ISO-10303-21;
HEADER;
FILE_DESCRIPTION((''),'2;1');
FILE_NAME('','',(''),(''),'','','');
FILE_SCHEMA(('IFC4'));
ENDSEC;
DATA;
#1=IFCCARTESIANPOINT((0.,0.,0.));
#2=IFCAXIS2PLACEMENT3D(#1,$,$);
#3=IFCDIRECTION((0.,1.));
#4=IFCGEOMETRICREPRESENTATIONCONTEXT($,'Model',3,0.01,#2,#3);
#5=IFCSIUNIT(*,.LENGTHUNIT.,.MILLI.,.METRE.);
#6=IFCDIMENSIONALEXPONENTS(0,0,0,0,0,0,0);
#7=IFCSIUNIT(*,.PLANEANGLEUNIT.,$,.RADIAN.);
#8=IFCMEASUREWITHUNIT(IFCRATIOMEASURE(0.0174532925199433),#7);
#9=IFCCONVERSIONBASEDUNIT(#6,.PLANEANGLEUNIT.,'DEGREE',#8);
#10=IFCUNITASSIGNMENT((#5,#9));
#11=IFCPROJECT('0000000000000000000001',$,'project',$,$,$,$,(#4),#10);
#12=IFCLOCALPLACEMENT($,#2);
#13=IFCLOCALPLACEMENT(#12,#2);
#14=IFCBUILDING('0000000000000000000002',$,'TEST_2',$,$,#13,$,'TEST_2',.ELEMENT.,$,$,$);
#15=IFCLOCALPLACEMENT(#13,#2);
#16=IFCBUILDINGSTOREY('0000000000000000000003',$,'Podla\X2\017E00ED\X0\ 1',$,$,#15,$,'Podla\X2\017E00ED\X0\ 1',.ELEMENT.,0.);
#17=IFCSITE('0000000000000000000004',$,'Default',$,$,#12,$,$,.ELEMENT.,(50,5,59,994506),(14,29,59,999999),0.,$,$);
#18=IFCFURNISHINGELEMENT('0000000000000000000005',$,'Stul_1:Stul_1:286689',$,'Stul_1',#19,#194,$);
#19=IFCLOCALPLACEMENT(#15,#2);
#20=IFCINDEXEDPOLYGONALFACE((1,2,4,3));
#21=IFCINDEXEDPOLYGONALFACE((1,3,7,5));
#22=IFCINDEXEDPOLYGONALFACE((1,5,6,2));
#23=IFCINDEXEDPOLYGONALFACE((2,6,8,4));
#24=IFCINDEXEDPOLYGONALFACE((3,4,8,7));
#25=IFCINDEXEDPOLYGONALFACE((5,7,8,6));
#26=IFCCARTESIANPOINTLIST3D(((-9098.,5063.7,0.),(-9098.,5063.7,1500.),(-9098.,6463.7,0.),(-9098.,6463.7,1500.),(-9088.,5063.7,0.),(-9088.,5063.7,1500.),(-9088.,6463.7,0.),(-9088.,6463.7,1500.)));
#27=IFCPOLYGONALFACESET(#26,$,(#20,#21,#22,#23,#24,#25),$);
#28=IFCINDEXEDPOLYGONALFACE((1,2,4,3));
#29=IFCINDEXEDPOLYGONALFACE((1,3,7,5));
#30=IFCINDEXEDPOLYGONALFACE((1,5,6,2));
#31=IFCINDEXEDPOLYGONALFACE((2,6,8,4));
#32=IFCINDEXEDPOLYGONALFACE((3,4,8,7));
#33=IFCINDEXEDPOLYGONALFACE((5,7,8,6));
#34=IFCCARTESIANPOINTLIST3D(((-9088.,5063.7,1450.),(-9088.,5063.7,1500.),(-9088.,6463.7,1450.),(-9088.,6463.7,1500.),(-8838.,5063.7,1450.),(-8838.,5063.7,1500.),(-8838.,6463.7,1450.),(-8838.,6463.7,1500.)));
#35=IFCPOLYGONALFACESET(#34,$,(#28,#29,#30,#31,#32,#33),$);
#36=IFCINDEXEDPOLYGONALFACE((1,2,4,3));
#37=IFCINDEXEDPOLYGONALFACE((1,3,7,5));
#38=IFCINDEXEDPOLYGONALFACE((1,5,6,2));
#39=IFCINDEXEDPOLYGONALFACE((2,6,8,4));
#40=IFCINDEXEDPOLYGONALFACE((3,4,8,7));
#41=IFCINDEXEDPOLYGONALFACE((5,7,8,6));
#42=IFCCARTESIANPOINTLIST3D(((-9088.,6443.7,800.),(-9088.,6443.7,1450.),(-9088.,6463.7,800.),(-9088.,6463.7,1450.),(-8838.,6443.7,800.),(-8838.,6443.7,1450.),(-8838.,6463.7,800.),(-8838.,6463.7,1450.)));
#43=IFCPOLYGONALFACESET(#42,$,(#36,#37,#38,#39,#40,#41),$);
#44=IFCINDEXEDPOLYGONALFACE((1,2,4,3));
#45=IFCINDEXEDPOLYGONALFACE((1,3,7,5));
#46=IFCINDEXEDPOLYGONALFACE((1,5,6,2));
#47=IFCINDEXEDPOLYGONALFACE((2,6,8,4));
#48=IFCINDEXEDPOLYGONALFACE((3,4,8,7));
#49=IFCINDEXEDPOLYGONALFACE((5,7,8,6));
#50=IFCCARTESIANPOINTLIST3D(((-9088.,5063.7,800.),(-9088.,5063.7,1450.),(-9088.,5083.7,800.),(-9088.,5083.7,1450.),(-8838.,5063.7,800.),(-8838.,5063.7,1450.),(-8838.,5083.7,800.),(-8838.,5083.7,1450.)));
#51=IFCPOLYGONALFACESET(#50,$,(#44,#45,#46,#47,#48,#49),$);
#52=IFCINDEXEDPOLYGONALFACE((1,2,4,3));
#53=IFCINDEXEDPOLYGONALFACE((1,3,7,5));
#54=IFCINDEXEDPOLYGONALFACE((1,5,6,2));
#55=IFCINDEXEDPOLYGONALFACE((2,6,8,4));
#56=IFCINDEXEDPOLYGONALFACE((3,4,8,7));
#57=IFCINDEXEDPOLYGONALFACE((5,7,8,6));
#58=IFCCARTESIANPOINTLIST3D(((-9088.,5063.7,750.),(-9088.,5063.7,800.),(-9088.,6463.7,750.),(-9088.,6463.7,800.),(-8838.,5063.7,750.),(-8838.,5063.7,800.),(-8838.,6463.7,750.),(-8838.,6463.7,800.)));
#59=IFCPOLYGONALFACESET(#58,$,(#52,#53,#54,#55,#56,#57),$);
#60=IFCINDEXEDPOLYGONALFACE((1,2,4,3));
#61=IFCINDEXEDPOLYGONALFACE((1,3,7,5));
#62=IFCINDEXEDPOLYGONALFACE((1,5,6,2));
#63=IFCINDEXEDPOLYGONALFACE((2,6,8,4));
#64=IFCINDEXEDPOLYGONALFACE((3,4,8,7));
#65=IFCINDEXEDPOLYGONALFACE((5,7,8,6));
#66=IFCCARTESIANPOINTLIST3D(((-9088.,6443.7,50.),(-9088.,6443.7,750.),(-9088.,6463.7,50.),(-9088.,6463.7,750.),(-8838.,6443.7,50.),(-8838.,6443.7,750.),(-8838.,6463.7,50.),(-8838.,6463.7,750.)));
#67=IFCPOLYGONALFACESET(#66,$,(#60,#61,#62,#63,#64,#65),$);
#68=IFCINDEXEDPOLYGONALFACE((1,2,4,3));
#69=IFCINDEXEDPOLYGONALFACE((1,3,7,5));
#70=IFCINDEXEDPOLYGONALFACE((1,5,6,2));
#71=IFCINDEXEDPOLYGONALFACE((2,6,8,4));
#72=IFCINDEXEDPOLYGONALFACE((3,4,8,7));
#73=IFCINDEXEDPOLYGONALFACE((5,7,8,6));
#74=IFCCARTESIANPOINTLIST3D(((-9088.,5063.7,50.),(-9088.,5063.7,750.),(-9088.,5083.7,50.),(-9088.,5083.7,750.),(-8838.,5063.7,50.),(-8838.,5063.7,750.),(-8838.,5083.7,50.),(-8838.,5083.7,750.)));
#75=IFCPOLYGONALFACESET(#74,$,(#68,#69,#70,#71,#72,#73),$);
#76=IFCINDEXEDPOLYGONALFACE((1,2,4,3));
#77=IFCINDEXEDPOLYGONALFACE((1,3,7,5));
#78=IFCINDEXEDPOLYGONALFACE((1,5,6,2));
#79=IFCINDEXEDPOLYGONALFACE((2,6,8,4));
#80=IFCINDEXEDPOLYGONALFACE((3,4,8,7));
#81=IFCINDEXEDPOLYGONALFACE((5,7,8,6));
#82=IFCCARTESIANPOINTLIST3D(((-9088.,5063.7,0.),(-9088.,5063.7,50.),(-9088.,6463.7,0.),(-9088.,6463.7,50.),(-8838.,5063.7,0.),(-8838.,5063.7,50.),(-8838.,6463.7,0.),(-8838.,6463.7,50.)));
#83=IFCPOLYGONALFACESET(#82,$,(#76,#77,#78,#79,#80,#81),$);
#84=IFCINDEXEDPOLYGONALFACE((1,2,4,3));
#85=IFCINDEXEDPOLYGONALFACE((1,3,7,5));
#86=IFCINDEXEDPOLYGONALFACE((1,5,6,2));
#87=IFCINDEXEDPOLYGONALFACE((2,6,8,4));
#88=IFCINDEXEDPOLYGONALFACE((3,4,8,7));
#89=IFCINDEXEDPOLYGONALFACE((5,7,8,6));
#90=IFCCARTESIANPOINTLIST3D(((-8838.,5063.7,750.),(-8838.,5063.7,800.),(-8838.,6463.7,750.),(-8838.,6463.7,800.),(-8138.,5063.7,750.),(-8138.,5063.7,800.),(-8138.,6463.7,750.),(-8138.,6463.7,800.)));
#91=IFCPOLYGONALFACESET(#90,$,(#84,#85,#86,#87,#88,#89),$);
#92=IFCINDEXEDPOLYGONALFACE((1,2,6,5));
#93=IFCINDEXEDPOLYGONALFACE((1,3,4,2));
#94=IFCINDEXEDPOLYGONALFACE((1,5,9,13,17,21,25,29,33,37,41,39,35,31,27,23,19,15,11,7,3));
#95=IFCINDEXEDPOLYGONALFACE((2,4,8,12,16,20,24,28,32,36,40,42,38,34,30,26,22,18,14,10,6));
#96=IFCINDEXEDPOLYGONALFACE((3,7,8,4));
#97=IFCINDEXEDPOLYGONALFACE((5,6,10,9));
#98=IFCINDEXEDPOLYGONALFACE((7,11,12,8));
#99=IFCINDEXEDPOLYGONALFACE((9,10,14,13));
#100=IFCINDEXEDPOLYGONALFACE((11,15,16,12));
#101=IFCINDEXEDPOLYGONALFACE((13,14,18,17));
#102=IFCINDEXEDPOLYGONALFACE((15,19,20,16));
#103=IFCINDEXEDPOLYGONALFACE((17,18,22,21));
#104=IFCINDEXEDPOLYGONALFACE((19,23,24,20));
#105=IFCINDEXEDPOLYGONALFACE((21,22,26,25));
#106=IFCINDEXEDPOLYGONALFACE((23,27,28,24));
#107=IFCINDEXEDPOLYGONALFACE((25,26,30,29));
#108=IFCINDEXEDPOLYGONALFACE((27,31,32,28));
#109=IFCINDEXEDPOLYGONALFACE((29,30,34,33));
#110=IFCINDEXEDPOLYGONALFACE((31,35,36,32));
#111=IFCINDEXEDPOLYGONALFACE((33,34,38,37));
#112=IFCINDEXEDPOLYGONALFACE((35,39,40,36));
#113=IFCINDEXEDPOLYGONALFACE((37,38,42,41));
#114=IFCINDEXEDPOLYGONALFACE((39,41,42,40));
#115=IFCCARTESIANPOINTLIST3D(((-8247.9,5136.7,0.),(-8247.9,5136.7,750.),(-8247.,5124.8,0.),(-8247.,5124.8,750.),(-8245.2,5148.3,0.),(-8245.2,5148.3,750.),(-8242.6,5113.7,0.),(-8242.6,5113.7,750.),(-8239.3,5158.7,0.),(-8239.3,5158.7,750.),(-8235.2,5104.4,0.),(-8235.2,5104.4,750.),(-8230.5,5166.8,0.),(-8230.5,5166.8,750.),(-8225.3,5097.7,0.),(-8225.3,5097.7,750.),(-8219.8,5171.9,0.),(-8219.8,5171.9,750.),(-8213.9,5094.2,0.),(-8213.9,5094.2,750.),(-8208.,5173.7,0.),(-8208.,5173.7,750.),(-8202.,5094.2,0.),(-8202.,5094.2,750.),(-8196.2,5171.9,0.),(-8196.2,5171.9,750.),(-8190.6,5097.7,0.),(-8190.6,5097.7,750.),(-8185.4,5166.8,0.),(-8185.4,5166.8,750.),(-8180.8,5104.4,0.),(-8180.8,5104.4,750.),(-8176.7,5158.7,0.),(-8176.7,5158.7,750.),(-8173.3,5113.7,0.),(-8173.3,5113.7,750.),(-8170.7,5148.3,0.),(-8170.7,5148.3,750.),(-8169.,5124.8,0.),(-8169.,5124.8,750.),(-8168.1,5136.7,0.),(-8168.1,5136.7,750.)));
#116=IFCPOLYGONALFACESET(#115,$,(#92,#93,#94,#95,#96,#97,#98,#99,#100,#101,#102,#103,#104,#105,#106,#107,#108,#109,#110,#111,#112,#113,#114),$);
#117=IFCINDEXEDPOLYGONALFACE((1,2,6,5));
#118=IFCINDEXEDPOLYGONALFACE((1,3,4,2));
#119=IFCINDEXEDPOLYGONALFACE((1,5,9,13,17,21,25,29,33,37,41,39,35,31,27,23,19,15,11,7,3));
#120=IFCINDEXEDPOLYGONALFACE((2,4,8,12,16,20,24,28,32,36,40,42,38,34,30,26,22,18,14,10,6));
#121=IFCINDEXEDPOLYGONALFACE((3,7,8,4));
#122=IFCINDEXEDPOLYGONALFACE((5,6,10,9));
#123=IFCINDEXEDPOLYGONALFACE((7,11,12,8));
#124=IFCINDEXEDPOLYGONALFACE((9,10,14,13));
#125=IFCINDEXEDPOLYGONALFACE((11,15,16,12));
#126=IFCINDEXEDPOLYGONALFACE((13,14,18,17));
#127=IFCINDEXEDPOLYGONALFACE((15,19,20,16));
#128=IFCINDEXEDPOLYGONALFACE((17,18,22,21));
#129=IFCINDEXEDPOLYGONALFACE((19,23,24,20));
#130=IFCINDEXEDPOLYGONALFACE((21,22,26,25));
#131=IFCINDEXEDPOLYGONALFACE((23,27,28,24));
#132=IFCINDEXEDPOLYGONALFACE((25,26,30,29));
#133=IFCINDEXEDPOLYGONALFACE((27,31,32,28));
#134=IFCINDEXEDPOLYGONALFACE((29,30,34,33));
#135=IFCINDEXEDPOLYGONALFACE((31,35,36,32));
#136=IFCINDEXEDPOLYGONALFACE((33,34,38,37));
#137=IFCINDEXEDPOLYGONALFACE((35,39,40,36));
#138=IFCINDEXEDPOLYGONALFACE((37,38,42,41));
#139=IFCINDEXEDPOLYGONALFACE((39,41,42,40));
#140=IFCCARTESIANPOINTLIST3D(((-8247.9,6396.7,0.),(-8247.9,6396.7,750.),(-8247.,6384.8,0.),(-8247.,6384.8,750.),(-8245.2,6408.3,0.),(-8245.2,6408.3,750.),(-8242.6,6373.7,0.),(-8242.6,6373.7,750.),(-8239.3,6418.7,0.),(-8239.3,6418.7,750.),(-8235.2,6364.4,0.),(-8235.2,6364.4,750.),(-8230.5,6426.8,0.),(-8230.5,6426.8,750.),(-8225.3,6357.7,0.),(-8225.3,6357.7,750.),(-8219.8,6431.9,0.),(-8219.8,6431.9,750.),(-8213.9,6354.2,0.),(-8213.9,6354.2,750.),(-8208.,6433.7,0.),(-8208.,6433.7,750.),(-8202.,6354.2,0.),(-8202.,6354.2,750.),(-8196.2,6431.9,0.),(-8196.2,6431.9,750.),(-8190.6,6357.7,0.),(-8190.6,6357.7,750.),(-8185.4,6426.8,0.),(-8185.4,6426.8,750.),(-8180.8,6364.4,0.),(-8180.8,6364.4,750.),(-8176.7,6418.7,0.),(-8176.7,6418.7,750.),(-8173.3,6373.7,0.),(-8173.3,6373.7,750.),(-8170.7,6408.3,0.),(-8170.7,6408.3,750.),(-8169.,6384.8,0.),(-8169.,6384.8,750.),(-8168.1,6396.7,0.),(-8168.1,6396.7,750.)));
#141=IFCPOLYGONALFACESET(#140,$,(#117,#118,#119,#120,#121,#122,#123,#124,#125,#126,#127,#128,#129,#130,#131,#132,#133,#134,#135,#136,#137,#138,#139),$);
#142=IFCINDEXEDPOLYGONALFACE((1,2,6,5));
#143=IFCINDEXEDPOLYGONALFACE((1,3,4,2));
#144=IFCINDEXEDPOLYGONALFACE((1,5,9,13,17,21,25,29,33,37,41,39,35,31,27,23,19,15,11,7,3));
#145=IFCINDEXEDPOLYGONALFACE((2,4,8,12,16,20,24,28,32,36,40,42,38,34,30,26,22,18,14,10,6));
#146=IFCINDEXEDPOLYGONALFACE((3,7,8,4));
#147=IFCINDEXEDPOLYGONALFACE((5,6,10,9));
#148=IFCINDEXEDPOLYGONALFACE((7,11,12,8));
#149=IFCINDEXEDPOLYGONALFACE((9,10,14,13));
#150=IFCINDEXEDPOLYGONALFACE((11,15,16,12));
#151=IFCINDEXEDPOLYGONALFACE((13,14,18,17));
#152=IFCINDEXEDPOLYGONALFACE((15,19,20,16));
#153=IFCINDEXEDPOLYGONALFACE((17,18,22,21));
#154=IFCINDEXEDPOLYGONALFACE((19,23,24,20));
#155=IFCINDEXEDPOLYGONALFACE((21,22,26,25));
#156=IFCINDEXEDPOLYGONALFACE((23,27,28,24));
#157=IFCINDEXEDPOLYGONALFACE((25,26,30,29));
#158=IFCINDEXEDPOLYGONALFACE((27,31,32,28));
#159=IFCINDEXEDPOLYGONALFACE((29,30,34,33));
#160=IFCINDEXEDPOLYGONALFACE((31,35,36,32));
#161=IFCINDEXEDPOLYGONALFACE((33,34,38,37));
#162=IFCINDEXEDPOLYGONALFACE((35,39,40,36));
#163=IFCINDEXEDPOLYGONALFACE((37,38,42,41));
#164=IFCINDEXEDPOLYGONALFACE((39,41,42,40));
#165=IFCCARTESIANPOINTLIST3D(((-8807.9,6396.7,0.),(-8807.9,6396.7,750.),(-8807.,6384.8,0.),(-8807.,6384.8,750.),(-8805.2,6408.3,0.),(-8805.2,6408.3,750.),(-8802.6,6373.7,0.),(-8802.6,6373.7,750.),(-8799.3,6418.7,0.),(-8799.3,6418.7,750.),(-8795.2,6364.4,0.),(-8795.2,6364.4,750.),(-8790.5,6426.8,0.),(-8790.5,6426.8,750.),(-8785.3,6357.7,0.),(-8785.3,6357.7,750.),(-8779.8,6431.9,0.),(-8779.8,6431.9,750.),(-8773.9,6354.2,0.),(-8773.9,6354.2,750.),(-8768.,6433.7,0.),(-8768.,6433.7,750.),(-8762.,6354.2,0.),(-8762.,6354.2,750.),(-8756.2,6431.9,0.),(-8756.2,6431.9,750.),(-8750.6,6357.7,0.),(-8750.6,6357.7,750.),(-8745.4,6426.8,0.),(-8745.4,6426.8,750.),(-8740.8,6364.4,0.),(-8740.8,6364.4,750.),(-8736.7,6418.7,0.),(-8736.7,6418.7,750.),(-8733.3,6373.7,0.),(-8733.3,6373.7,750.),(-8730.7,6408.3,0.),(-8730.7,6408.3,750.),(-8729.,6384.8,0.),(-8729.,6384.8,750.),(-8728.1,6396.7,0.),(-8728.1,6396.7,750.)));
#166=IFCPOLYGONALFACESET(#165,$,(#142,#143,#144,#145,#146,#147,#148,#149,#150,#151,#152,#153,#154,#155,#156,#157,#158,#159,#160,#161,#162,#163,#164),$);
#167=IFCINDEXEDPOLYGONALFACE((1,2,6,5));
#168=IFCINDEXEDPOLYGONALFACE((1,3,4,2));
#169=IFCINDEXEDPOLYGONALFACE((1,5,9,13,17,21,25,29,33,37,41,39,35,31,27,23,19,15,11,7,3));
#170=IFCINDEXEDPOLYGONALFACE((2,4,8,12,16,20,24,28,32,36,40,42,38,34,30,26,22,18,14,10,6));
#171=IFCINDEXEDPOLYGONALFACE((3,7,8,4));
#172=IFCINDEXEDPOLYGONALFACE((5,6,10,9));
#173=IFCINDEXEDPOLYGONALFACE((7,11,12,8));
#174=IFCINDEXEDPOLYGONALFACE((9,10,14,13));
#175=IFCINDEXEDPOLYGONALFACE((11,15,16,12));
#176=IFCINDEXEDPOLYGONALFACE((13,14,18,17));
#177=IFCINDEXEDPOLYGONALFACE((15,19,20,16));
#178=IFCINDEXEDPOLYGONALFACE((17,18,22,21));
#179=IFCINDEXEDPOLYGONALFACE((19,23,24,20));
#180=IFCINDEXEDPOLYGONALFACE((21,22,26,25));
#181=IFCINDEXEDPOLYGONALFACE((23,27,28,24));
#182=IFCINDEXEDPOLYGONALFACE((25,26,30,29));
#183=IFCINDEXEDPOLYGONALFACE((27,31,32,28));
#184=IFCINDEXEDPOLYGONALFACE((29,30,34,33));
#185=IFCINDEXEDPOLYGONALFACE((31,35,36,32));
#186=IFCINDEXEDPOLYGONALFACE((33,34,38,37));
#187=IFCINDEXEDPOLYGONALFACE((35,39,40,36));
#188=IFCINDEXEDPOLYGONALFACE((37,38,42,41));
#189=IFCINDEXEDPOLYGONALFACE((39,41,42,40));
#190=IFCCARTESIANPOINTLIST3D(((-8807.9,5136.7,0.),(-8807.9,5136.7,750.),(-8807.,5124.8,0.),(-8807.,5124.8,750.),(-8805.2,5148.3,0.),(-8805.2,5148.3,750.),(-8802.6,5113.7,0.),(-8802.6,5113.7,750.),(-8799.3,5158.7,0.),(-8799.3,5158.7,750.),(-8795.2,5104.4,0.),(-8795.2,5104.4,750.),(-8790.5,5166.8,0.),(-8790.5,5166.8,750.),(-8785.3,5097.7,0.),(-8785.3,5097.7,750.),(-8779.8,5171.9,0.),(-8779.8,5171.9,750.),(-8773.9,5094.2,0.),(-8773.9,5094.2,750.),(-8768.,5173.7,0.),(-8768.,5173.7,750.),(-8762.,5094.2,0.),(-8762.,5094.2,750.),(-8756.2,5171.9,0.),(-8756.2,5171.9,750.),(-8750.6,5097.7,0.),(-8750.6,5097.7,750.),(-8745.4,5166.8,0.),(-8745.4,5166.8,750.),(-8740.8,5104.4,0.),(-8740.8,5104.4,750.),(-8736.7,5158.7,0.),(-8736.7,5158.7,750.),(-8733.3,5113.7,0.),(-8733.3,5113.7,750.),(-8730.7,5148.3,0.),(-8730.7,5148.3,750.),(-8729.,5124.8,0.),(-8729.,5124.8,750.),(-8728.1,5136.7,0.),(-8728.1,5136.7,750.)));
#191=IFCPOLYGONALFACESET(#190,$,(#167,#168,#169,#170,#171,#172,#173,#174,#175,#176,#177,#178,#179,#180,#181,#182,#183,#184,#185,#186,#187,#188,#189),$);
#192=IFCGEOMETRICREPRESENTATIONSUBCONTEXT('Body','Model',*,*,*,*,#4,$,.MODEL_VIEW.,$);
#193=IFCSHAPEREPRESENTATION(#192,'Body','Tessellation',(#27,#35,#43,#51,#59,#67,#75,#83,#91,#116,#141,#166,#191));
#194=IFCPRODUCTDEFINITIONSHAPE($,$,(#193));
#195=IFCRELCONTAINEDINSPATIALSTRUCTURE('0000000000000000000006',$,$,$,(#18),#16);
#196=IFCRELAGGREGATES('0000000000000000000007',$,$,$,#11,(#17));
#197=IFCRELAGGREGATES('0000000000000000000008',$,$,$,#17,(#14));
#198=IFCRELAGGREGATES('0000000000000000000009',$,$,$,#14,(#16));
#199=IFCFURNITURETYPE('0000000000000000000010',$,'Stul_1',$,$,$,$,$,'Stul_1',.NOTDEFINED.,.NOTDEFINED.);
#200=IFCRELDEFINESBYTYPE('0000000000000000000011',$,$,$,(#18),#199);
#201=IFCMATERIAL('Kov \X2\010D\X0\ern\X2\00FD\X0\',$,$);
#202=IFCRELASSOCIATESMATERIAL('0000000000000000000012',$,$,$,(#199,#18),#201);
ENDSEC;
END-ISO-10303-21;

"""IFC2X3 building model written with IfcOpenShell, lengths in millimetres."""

from ifc_helpers import new_model, entity, si_unit, converted_unit, direction, frame, frame_2d, origin, origin_2d_with_axis, place, context, subcontext, project, spatial, rectangle, circle, extrude, source, transform, mapped, material, type_object, type_shapes, element, save


model = new_model("IFC2X3")

# Units and contexts
model_context = context("Model", 3, precision=0.01, world=origin(), true_north=direction((0.0, 1.0)))
body_context = subcontext(model_context, "Body", "Model", "MODEL_VIEW")
ifc_project = project(units=[si_unit("LENGTHUNIT", "METRE", prefix="MILLI"), converted_unit("PLANEANGLEUNIT", "DEGREE", entity("IfcRatioMeasure", 0.0174532925199433), si_unit("PLANEANGLEUNIT", "RADIAN"), dimensions=[0, 0, 0, 0, 0, 0, 0])], contexts=[model_context])

# Site, building, storey
site_placement = place(None, origin())
site = spatial("IfcSite", under=ifc_project, at=site_placement, Name="Default", CompositionType="ELEMENT", RefLatitude=(50, 5, 59, 994506), RefLongitude=(14, 29, 59, 999999), RefElevation=0.0)
building_placement = place(site_placement, origin())
building = spatial("IfcBuilding", under=site, at=building_placement, Name="TEST_2", LongName="TEST_2", CompositionType="ELEMENT")
storey_placement = place(building_placement, origin())
storey = spatial("IfcBuildingStorey", under=building, at=storey_placement, Name="Podlaží 1", LongName="Podlaží 1", CompositionType="ELEMENT", Elevation=0.0)

# Furnishing element
ifc_material_1 = material(Name="Kov černý")
furniture_type = type_object("IfcFurnitureType", Name="Stul_1", ElementType="Stul_1", material=ifc_material_1)
shared_shape_1 = source(origin(), body_context, "Body", "SweptSolid", [
    extrude(rectangle(XDim=1400.0, YDim=10.0, at=origin_2d_with_axis()), frame((0.0, 605.0, 0.0), z_axis=(0.0, 0.0, 1.0), x_axis=(-1.0, 0.0, 0.0)), (0.0, 0.0, 1.0), 1500.0),
    extrude(rectangle(XDim=1400.0, YDim=250.0, at=frame_2d((0.0, 0.0), x_axis=(1.0, 0.0))), frame((0.0, 475.0, 1450.0), z_axis=(0.0, 0.0, 1.0), x_axis=(-1.0, 0.0, 0.0)), (0.0, 0.0, 1.0), 50.0),
    extrude(rectangle(XDim=20.0, YDim=250.0, at=origin_2d_with_axis()), frame((690.0, 475.0, 800.0), z_axis=(0.0, 0.0, 1.0), x_axis=(-1.0, 0.0, 0.0)), (0.0, 0.0, 1.0), 650.0),
    extrude(rectangle(XDim=20.0, YDim=250.0, at=frame_2d((0.0, 0.0), x_axis=(1.0, 0.0))), frame((-690.0, 475.0, 800.0), z_axis=(0.0, 0.0, 1.0), x_axis=(-1.0, 0.0, 0.0)), (0.0, 0.0, 1.0), 650.0),
    extrude(rectangle(XDim=1400.0, YDim=250.0, at=origin_2d_with_axis()), frame((0.0, 475.0, 750.0), z_axis=(0.0, 0.0, 1.0), x_axis=(-1.0, 0.0, 0.0)), (0.0, 0.0, 1.0), 50.0),
    extrude(rectangle(XDim=20.0, YDim=250.0, at=origin_2d_with_axis()), frame((690.0, 475.0, 50.0), z_axis=(0.0, 0.0, 1.0), x_axis=(-1.0, 0.0, 0.0)), (0.0, 0.0, 1.0), 700.0),
    extrude(rectangle(XDim=20.0, YDim=250.0, at=frame_2d((0.0, 0.0), x_axis=(1.0, 0.0))), frame((-690.0, 475.0, 50.0), z_axis=(0.0, 0.0, 1.0), x_axis=(-1.0, 0.0, 0.0)), (0.0, 0.0, 1.0), 700.0),
    extrude(rectangle(XDim=1400.0, YDim=250.0, at=origin_2d_with_axis()), frame((0.0, 475.0, 0.0), z_axis=(0.0, 0.0, 1.0), x_axis=(-1.0, 0.0, 0.0)), (0.0, 0.0, 1.0), 50.0),
    extrude(rectangle(XDim=1400.0, YDim=700.0, at=origin_2d_with_axis()), frame((0.0, 0.0, 750.0), z_axis=(0.0, 0.0, 1.0), x_axis=(-1.0, 0.0, 0.0)), (0.0, 0.0, 1.0), 50.0),
    extrude(circle(Radius=40.0, at=frame_2d((0.0, 0.0), x_axis=(1.0, 0.0))), frame((-630.0, -280.0, 0.0)), (0.0, 0.0, 1.0), 750.0),
    extrude(circle(Radius=40.0, at=frame_2d((0.0, 0.0), x_axis=(1.0, 0.0))), frame((630.0, -280.0, 0.0)), (0.0, 0.0, 1.0), 750.0),
    extrude(circle(Radius=40.0, at=frame_2d((0.0, 0.0), x_axis=(1.0, 0.0))), frame((630.0, 280.0, 0.0)), (0.0, 0.0, 1.0), 750.0),
    extrude(circle(Radius=40.0, at=frame_2d((0.0, 0.0), x_axis=(1.0, 0.0))), frame((-630.0, 280.0, 0.0)), (0.0, 0.0, 1.0), 750.0),
])
type_shapes(furniture_type, [shared_shape_1])
for number, where, z_axis, x_axis, name in (
    (1, (-8488.0, 5763.7, 0.0), (0.0, 0.0, 1.0), (0.0, 1.0, 0.0), "Stul_1:Stul_1:286689"),
):
    element("IfcFurnishingElement", number, at=place(storey_placement, frame(where, z_axis=z_axis, x_axis=x_axis)), inside=storey, type_object=furniture_type, material=ifc_material_1, Name=name, ObjectType="Stul_1", context=body_context, shape_type="MappedRepresentation", body=[
        mapped(shared_shape_1, transform((0.0, 0.0, 0.0), scale=1.0)),
    ])

save(model, "model.ifc")
